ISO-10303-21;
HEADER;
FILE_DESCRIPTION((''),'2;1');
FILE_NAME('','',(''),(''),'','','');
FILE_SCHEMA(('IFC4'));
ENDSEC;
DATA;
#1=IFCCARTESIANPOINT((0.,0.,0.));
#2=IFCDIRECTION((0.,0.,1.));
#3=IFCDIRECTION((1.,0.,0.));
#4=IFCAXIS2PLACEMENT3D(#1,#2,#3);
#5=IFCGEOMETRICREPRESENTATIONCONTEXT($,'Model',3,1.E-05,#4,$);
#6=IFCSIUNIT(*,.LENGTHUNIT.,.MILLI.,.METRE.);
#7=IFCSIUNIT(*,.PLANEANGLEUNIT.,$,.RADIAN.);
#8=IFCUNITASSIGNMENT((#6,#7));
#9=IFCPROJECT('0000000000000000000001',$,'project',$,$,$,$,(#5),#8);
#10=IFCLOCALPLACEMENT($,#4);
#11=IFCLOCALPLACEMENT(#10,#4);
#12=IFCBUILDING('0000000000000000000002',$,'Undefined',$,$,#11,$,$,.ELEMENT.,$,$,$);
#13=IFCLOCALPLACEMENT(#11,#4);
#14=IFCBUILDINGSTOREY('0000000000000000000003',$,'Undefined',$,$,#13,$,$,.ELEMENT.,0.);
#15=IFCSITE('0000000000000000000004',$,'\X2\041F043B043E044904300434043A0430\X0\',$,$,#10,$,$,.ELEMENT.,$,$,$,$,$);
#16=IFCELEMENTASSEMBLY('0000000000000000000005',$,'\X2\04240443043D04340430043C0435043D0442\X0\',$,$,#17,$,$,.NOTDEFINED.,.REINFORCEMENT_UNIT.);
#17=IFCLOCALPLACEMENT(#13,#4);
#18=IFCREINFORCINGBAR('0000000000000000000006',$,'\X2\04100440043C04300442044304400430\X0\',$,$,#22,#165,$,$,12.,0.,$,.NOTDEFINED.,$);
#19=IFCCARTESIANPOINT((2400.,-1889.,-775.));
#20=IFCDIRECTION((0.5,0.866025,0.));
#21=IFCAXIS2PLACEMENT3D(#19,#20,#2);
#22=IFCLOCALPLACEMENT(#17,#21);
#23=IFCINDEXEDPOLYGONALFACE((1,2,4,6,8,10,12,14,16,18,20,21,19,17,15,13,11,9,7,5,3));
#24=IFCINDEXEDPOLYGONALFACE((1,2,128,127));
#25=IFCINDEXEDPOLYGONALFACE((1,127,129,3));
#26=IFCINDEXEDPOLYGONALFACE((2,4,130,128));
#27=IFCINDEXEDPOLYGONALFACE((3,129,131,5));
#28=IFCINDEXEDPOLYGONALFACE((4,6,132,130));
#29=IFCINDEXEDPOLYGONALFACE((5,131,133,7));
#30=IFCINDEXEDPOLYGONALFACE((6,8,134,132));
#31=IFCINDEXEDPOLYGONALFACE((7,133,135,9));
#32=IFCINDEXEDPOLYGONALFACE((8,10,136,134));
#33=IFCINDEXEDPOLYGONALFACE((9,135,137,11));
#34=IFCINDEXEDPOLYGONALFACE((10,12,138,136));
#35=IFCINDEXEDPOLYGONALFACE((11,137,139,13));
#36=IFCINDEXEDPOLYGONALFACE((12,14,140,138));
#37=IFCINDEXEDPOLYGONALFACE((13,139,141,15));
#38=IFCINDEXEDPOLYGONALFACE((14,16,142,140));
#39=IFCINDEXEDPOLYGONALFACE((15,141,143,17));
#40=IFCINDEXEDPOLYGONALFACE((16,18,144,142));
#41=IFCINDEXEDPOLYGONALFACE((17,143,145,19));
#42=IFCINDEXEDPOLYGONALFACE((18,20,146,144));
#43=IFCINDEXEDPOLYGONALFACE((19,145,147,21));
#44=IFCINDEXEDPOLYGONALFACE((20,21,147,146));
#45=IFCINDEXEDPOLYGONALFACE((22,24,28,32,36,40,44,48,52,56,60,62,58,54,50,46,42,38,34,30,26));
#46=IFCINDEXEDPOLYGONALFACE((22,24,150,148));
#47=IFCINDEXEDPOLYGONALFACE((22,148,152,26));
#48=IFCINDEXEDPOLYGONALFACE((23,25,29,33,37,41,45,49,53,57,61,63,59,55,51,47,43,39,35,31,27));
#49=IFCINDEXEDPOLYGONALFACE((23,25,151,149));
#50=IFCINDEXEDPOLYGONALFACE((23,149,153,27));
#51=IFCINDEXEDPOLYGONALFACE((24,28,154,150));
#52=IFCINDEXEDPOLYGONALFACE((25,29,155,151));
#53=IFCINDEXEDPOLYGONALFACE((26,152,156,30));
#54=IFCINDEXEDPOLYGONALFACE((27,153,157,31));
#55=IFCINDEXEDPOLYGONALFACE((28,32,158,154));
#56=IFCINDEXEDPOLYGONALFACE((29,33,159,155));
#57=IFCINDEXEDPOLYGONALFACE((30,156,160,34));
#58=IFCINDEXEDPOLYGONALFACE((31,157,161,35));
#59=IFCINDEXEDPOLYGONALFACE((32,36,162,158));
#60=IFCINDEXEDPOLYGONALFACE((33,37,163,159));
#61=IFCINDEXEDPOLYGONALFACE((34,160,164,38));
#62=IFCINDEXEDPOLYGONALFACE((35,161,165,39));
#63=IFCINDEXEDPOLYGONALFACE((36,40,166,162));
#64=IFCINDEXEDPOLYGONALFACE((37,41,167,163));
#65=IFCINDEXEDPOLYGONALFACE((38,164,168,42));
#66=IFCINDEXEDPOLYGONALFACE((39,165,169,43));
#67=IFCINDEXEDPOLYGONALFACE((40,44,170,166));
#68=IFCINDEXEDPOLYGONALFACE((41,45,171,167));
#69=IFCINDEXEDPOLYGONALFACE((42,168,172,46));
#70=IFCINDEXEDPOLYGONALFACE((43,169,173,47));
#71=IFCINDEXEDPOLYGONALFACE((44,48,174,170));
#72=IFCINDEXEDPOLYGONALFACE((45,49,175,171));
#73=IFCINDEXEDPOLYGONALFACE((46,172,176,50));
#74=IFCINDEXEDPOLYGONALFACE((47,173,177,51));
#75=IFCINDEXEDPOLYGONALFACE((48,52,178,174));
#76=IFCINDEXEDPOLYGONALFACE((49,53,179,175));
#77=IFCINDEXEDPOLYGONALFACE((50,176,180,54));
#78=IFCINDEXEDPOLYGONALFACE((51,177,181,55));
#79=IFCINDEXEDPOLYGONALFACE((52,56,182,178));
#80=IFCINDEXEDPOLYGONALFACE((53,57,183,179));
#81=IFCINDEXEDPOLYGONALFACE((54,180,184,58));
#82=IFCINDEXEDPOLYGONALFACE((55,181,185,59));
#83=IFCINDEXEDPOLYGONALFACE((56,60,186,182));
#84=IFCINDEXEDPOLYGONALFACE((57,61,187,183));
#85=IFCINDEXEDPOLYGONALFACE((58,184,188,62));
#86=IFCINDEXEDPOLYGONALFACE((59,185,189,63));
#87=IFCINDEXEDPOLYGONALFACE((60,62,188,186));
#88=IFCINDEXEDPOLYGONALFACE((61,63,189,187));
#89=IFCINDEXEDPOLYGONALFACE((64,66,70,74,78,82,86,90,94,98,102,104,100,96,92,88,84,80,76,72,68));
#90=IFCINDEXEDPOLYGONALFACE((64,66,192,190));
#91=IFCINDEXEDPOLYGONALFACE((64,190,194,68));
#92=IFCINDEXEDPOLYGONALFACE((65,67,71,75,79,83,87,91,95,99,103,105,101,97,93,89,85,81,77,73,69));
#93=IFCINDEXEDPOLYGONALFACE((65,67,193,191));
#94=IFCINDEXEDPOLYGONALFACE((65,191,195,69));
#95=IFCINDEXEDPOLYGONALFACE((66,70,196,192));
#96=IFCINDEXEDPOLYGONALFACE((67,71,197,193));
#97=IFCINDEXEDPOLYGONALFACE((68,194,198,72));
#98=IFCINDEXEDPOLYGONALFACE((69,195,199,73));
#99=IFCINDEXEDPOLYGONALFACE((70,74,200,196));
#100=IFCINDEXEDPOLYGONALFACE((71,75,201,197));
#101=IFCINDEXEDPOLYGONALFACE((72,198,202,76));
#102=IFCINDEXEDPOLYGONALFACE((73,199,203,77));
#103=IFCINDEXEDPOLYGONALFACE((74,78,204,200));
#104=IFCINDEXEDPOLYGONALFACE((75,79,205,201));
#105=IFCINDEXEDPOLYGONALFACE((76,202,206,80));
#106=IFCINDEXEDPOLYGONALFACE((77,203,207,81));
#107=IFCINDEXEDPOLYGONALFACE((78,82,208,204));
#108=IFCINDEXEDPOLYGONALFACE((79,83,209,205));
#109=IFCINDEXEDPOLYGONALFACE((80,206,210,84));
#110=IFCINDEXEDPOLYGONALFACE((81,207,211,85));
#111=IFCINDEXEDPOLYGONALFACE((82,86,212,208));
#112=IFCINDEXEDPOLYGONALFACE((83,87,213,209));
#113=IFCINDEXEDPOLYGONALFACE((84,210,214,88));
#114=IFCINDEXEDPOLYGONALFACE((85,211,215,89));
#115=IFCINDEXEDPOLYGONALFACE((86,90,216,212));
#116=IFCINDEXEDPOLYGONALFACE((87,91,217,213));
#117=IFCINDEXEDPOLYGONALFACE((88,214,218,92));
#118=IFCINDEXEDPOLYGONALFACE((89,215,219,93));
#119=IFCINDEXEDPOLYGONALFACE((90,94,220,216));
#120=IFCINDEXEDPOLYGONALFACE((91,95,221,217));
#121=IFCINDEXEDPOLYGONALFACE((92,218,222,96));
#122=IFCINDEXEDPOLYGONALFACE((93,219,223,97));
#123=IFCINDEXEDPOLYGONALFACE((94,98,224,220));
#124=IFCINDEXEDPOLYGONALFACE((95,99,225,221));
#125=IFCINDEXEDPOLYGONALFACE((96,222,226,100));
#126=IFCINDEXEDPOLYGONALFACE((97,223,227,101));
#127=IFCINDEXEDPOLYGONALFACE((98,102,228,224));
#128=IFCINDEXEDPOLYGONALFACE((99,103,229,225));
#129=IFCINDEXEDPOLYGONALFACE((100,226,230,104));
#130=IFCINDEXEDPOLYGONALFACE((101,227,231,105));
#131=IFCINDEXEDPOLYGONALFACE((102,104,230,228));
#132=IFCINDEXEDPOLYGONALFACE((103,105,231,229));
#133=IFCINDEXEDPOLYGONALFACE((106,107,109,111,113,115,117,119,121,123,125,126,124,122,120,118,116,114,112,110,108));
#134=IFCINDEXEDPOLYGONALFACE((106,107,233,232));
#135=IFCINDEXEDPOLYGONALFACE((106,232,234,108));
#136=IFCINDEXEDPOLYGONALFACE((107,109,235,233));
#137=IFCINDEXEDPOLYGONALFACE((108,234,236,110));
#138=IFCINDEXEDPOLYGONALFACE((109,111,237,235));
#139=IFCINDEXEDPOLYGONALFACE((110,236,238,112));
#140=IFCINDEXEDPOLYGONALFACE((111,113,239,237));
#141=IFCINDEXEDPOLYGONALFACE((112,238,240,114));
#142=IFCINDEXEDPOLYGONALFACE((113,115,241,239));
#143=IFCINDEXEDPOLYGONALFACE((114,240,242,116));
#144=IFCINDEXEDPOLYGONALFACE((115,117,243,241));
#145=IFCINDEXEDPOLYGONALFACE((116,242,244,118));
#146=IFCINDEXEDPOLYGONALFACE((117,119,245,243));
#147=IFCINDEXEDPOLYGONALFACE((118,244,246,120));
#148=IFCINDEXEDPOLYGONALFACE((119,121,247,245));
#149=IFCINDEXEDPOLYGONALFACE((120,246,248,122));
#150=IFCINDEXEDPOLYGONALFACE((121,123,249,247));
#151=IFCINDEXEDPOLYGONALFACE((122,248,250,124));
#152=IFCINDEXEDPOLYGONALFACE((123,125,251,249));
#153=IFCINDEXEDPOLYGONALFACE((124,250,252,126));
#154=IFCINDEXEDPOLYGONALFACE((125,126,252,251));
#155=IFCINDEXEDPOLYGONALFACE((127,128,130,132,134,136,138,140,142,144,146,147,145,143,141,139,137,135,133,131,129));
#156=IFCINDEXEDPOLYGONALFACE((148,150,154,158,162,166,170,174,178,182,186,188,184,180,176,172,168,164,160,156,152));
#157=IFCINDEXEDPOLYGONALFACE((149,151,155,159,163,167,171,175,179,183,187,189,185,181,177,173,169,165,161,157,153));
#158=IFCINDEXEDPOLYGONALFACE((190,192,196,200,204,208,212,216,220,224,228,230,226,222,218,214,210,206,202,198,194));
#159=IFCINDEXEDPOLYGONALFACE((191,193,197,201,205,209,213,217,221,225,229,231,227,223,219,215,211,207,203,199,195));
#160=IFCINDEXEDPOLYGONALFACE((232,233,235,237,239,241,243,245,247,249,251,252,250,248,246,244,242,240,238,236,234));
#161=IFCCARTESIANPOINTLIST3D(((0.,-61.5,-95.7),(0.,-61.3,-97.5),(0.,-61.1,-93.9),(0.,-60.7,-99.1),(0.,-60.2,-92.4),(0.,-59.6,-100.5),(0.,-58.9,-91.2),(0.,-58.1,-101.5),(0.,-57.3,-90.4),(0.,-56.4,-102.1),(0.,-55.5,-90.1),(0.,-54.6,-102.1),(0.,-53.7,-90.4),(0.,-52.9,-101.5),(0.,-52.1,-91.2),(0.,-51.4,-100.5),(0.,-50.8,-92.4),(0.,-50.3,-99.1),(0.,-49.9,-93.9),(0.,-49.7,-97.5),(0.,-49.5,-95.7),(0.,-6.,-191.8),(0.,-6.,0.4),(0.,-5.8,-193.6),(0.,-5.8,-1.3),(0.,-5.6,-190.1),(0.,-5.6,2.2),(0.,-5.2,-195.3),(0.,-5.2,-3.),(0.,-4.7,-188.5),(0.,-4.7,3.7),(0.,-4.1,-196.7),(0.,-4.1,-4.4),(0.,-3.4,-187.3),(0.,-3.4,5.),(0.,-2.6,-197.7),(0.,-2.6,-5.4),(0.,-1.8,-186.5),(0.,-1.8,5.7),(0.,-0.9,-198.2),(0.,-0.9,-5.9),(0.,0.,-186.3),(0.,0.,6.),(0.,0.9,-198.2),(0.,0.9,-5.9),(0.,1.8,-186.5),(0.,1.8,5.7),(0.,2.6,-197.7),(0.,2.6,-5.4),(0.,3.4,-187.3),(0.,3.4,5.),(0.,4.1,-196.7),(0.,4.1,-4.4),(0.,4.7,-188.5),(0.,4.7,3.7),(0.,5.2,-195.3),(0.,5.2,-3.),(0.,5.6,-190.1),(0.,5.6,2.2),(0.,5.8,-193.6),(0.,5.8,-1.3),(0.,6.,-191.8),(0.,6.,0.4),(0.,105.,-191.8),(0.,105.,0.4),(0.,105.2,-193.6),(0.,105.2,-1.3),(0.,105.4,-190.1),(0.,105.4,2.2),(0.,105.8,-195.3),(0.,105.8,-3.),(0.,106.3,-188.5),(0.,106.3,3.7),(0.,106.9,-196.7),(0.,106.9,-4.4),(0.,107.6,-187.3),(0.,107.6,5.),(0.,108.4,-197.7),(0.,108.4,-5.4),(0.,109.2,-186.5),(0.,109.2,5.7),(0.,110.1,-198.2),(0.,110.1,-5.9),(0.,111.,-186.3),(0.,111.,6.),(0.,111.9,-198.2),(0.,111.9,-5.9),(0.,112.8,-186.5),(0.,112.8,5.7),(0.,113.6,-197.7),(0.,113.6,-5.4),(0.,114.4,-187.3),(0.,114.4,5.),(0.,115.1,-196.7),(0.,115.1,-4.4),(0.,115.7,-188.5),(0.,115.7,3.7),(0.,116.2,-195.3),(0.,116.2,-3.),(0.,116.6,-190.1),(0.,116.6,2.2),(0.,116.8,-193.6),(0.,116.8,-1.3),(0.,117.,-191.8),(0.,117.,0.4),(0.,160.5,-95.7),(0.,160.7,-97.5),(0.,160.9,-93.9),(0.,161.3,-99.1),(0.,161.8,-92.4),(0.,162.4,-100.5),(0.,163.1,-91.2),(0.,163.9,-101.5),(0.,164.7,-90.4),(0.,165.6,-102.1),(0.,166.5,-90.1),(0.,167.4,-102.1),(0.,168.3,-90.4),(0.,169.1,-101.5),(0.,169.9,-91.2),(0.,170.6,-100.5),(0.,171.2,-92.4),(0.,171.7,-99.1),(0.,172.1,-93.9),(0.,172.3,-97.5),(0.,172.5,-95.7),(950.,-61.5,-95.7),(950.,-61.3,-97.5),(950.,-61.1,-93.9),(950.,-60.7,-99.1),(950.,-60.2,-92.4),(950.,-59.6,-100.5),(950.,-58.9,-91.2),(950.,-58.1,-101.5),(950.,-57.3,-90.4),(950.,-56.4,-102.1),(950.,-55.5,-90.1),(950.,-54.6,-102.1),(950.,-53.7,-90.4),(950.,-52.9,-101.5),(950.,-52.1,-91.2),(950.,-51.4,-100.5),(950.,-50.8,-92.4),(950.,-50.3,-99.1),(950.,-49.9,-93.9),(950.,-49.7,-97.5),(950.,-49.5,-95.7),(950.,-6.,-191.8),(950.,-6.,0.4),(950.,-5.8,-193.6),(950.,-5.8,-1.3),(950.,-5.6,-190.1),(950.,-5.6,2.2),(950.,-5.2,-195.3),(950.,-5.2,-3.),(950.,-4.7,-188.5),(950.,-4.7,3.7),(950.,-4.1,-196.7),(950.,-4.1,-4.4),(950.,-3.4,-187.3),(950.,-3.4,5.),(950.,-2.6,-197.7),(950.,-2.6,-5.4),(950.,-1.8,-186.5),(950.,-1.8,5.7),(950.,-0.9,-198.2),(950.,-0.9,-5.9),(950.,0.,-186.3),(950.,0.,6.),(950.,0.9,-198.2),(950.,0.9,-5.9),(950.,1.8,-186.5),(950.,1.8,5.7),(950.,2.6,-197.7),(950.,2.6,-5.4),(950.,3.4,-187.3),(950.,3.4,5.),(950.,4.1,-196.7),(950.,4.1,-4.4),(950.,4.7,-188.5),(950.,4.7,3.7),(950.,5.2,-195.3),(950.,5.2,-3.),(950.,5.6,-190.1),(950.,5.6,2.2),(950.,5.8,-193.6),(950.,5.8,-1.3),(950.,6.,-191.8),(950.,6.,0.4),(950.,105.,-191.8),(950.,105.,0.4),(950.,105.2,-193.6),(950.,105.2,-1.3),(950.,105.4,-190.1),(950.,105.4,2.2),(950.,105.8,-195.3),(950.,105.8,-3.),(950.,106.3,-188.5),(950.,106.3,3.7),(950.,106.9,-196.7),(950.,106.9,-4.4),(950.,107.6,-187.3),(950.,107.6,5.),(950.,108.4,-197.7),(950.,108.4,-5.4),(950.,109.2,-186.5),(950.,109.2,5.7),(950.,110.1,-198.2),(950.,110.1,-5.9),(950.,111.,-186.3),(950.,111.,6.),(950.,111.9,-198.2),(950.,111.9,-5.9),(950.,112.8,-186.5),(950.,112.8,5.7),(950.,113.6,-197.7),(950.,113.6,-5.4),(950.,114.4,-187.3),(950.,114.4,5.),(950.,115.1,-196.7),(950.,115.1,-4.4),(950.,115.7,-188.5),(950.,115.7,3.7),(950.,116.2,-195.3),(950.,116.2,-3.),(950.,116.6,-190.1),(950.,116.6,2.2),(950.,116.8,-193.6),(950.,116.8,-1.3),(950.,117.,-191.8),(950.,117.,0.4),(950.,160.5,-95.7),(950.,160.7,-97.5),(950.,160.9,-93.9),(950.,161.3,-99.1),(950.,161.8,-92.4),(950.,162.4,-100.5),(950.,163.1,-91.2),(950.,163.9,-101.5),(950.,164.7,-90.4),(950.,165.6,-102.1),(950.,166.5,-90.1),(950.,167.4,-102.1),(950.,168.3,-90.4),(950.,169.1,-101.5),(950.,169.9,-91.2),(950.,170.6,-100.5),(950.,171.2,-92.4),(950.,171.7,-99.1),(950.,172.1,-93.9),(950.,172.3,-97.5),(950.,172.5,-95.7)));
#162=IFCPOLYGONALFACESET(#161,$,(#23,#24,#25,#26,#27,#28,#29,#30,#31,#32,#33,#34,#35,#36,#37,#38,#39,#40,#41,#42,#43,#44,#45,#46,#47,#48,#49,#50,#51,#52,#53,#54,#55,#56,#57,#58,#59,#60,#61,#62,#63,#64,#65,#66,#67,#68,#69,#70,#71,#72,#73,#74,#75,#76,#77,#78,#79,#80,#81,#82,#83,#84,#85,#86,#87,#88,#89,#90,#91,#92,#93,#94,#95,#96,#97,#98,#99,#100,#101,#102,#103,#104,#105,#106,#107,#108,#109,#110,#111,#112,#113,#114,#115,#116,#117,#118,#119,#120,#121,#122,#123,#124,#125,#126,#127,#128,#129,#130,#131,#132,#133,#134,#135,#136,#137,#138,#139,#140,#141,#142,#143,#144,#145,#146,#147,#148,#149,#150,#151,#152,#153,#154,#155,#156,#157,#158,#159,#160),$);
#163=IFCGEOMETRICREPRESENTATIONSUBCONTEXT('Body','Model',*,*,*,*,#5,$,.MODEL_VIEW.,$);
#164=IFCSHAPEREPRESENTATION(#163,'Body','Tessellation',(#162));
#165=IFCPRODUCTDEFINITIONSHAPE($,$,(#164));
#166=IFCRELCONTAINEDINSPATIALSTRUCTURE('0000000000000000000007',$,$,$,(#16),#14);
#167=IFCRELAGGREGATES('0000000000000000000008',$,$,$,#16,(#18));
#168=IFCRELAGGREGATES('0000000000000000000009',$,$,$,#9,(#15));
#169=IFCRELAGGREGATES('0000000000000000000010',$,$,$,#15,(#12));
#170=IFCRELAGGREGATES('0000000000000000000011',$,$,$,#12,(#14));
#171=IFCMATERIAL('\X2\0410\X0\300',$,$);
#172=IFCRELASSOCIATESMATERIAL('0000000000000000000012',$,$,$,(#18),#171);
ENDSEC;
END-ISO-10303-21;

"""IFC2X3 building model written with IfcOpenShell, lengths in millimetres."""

from ifc_helpers import new_model, entity, si_unit, frame, origin_with_axes, place, context, subcontext, project, spatial, source, transform, mapped, material, element, aggregate, save


model = new_model("IFC2X3")

# Units and contexts
model_context = context("Model", 3, precision=1e-05, world=origin_with_axes())
body_context = subcontext(model_context, "Body", "Model", "MODEL_VIEW")
ifc_project = project(units=[si_unit("LENGTHUNIT", "METRE", prefix="MILLI"), si_unit("PLANEANGLEUNIT", "RADIAN")], contexts=[model_context])

# Site, building, storey
site_placement = place(None, origin_with_axes())
site = spatial("IfcSite", under=ifc_project, at=site_placement, Name="Площадка", CompositionType="ELEMENT")
building_placement = place(site_placement, origin_with_axes())
building = spatial("IfcBuilding", under=site, at=building_placement, Name="Undefined", CompositionType="ELEMENT")
storey_placement = place(building_placement, origin_with_axes())
storey = spatial("IfcBuildingStorey", under=building, at=storey_placement, Name="Undefined", CompositionType="ELEMENT", Elevation=0.0)

# Element assembly
assembly_1_placement = place(storey_placement, origin_with_axes())
assembly_1 = element("IfcElementAssembly", 1, at=assembly_1_placement, inside=storey, Name="Фундамент", AssemblyPlace="NOTDEFINED", PredefinedType="REINFORCEMENT_UNIT")

# Reinforcing bar
ifc_material_1 = material(Name="А300")
shared_shape_1 = source(origin_with_axes(), body_context, "Body", "AdvancedSweptSolid", [
    entity("IfcSweptDiskSolid", entity("IfcTrimmedCurve", entity("IfcLine", entity("IfcCartesianPoint", [0.0, 0.0, 0.0]), entity("IfcVector", entity("IfcDirection", [1.0, 0.0, 0.0]), 1.0)), [entity("IfcParameterValue", 0.0)], [entity("IfcParameterValue", 950.0)], True, "PARAMETER"), 6.0, None, 0.0, 950.0),
])
shared_shape_2 = source(origin_with_axes(), body_context, "Body", "AdvancedSweptSolid", [
    entity("IfcSweptDiskSolid", entity("IfcTrimmedCurve", entity("IfcLine", entity("IfcCartesianPoint", [0.0, 0.0, 0.0]), entity("IfcVector", entity("IfcDirection", [1.0, 0.0, 0.0]), 1.0)), [entity("IfcParameterValue", 0.0)], [entity("IfcParameterValue", 950.0)], True, "PARAMETER"), 6.0, None, 0.0, 950.0),
])
shared_shape_3 = source(origin_with_axes(), body_context, "Body", "AdvancedSweptSolid", [
    entity("IfcSweptDiskSolid", entity("IfcTrimmedCurve", entity("IfcLine", entity("IfcCartesianPoint", [0.0, 0.0, 0.0]), entity("IfcVector", entity("IfcDirection", [1.0, 0.0, 0.0]), 1.0)), [entity("IfcParameterValue", 0.0)], [entity("IfcParameterValue", 950.0)], True, "PARAMETER"), 6.0, None, 0.0, 950.0),
])
shared_shape_4 = source(origin_with_axes(), body_context, "Body", "AdvancedSweptSolid", [
    entity("IfcSweptDiskSolid", entity("IfcTrimmedCurve", entity("IfcLine", entity("IfcCartesianPoint", [0.0, 0.0, 0.0]), entity("IfcVector", entity("IfcDirection", [1.0, 0.0, 0.0]), 1.0)), [entity("IfcParameterValue", 0.0)], [entity("IfcParameterValue", 950.0)], True, "PARAMETER"), 6.0, None, 0.0, 950.0),
])
shared_shape_5 = source(origin_with_axes(), body_context, "Body", "AdvancedSweptSolid", [
    entity("IfcSweptDiskSolid", entity("IfcTrimmedCurve", entity("IfcLine", entity("IfcCartesianPoint", [0.0, 0.0, 0.0]), entity("IfcVector", entity("IfcDirection", [1.0, 0.0, 0.0]), 1.0)), [entity("IfcParameterValue", 0.0)], [entity("IfcParameterValue", 950.0)], True, "PARAMETER"), 6.0, None, 0.0, 950.0),
])
shared_shape_6 = source(origin_with_axes(), body_context, "Body", "AdvancedSweptSolid", [
    entity("IfcSweptDiskSolid", entity("IfcTrimmedCurve", entity("IfcLine", entity("IfcCartesianPoint", [0.0, 0.0, 0.0]), entity("IfcVector", entity("IfcDirection", [1.0, 0.0, 0.0]), 1.0)), [entity("IfcParameterValue", 0.0)], [entity("IfcParameterValue", 950.0)], True, "PARAMETER"), 6.0, None, 0.0, 950.0),
])
reinforcing_bar_1_placement = place(assembly_1_placement, frame((2400.0, -1889.0, -775.0), z_axis=(0.5, 0.866025, 0.0), x_axis=(0.0, 0.0, 1.0)))
reinforcing_bar_1 = element("IfcReinforcingBar", 2, at=reinforcing_bar_1_placement, material=ifc_material_1, Name="Арматура", BarRole="NOTDEFINED", CrossSectionArea=0.0, NominalDiameter=12.0, context=body_context, shape_type="MappedRepresentation", body=[
    mapped(shared_shape_1, transform((0.0, 0.0, 0.0))),
    mapped(shared_shape_2, transform((0.0, -55.5, -96.1))),
    mapped(shared_shape_3, transform((0.0, 0.0, -192.3))),
    mapped(shared_shape_4, transform((0.0, 111.0, -192.3))),
    mapped(shared_shape_5, transform((0.0, 166.5, -96.1))),
    mapped(shared_shape_6, transform((0.0, 111.0, 0.0))),
])
aggregate(assembly_1, [reinforcing_bar_1])

save(model, "model.ifc")
